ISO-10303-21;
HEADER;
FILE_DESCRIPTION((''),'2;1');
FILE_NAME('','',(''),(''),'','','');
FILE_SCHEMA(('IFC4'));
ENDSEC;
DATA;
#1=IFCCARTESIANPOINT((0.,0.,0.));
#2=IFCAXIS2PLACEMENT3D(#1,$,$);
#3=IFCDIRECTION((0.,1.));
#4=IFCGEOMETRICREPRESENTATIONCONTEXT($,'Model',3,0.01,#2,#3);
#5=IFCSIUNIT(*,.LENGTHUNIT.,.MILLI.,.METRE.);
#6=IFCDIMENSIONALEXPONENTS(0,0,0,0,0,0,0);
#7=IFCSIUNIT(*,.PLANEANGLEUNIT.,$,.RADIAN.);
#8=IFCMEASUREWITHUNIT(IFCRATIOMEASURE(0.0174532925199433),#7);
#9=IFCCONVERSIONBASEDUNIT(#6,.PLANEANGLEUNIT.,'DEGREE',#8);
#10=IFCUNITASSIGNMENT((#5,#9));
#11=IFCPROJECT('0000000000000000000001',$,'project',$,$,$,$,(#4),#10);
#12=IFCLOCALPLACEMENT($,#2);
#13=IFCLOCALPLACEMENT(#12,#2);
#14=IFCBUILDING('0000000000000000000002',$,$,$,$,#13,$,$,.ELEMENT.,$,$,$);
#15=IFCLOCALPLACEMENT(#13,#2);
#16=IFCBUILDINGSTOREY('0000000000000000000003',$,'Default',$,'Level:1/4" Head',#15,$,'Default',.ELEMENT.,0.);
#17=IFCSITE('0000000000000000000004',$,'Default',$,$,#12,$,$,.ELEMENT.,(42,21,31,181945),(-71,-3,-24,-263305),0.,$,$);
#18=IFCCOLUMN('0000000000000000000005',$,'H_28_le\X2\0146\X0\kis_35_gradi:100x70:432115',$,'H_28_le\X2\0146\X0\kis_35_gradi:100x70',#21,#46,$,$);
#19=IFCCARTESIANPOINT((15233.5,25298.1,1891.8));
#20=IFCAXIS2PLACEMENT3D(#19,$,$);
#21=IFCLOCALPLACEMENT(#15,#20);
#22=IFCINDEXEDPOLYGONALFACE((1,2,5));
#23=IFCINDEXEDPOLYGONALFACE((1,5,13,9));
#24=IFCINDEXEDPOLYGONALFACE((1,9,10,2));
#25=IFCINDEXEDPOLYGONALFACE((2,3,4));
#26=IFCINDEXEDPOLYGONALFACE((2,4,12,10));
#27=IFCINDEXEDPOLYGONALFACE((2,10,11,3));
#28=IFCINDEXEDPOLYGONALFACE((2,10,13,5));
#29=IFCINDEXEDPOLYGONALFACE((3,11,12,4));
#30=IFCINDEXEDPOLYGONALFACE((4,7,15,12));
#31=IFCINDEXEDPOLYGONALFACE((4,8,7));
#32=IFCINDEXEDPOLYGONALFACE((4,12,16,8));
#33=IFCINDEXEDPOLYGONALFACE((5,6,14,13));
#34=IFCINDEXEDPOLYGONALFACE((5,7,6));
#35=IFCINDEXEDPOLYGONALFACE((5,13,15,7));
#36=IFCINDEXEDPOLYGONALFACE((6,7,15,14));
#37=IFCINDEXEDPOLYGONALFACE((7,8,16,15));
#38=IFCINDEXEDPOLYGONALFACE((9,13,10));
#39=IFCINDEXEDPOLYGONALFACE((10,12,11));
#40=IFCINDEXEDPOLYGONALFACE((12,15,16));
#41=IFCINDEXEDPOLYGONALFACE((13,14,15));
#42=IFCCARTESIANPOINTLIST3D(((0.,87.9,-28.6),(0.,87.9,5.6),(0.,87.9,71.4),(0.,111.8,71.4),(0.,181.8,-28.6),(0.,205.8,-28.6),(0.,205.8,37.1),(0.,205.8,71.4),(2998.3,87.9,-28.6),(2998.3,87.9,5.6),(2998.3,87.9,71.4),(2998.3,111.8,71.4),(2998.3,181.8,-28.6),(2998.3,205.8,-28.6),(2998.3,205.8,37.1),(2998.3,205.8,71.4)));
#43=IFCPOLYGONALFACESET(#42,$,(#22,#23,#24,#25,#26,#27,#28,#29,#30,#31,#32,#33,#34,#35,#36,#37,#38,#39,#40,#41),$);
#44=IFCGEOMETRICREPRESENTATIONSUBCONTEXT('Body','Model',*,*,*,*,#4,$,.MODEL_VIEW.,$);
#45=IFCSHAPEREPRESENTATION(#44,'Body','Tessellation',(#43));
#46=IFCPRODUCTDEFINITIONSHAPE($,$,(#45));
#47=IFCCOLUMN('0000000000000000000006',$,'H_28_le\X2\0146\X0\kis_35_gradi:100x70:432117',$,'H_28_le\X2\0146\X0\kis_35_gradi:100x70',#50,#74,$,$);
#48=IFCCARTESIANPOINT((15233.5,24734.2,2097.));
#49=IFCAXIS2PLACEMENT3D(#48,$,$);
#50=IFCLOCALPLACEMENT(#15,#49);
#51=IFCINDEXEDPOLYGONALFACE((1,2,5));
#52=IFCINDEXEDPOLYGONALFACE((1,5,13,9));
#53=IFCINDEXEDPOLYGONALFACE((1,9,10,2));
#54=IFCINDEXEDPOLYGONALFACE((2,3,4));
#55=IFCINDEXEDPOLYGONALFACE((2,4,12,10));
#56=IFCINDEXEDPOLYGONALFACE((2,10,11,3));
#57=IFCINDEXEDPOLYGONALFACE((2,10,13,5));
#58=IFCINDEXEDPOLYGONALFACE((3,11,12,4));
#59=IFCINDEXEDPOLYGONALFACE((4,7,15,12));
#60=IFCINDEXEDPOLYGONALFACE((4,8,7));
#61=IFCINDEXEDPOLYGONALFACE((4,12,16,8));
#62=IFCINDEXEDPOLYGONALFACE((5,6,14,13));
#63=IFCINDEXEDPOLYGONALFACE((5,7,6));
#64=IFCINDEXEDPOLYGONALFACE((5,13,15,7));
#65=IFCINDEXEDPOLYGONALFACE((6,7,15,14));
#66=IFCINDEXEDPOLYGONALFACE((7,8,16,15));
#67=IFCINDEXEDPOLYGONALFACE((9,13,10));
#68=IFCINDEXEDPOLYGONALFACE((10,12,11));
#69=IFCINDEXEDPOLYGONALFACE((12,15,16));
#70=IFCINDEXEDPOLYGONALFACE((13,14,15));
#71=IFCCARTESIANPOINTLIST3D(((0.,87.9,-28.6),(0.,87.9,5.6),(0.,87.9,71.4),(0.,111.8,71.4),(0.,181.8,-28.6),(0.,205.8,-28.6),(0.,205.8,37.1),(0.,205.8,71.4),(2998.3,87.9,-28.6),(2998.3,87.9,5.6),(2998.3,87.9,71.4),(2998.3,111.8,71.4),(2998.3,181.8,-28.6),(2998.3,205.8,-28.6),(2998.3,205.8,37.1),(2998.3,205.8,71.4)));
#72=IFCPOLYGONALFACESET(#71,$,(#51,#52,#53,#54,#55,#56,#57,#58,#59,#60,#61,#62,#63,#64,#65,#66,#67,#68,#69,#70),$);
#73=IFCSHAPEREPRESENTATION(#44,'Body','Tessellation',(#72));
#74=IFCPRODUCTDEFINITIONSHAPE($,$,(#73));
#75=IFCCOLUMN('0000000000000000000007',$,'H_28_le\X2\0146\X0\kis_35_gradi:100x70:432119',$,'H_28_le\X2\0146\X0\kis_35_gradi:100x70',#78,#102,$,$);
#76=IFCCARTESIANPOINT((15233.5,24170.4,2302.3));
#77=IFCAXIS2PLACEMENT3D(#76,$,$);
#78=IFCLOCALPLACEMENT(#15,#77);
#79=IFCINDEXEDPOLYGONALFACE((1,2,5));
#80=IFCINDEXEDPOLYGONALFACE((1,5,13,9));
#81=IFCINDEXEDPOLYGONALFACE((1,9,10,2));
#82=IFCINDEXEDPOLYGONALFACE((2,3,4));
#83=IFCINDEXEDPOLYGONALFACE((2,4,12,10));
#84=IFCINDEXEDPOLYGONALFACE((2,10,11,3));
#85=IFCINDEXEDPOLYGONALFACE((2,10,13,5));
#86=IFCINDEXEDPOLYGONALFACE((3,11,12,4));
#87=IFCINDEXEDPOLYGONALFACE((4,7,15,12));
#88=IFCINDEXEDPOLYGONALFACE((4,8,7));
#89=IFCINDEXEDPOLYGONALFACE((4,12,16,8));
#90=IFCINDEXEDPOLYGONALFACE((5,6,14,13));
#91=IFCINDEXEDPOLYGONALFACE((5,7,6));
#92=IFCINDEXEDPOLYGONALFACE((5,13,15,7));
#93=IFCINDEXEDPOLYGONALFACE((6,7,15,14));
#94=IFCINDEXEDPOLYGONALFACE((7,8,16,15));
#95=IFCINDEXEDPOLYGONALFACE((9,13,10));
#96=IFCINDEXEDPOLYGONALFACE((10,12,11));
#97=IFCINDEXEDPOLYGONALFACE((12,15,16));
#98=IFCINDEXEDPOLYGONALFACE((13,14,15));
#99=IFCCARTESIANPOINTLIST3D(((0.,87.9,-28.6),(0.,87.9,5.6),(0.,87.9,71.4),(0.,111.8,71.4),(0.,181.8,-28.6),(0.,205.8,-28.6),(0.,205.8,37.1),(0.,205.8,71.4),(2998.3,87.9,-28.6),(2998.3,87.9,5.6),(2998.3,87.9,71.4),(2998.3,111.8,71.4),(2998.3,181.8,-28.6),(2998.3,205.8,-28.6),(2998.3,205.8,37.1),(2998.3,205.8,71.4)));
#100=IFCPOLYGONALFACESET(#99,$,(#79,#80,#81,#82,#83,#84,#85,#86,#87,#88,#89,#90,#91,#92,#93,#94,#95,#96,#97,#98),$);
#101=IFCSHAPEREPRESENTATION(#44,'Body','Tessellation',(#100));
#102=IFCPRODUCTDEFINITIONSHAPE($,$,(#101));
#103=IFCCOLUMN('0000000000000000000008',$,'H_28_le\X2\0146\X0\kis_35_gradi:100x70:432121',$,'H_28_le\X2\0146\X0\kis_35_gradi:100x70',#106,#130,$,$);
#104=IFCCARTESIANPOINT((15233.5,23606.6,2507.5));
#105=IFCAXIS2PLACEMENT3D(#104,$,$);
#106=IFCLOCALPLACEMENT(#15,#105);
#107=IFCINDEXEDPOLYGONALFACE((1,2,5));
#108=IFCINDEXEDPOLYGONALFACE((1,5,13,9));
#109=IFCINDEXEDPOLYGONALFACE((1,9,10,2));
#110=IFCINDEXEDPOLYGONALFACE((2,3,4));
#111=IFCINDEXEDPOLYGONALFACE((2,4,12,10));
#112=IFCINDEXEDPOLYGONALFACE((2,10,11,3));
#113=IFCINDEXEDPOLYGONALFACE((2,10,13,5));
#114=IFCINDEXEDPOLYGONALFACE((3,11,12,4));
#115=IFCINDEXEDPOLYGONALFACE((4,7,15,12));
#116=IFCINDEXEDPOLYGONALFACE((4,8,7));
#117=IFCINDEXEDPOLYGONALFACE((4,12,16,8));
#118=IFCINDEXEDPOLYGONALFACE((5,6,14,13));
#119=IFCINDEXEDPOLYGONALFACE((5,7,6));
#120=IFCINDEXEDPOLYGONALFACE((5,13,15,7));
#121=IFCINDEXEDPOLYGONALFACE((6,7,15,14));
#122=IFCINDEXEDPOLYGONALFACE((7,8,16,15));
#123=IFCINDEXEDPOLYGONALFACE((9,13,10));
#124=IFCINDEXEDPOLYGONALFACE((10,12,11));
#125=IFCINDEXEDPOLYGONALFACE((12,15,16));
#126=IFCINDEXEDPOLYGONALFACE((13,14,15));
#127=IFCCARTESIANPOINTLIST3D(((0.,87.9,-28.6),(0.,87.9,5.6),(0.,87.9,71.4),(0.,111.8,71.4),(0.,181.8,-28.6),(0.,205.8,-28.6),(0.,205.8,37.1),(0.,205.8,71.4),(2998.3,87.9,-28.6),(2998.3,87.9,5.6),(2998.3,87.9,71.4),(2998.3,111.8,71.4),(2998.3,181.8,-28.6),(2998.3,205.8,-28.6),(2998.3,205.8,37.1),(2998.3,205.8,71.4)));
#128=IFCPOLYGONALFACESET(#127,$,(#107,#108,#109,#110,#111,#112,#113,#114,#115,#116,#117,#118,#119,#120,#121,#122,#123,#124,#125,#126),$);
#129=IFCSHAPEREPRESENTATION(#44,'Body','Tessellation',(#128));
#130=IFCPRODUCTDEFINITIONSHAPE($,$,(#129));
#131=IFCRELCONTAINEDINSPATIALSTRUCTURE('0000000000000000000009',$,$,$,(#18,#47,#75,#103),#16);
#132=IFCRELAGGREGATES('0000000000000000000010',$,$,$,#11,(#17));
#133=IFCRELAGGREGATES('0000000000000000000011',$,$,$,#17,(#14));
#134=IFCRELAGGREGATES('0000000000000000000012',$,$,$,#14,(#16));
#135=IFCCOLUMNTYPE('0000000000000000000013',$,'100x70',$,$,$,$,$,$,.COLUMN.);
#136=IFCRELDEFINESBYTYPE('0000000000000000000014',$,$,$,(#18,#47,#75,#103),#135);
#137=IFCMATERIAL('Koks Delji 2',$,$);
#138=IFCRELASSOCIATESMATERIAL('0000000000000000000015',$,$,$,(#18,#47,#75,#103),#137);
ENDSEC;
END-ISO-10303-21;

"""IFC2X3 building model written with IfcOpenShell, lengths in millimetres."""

from ifc_helpers import new_model, entity, si_unit, converted_unit, direction, frame, frame_2d, origin, place, context, subcontext, project, spatial, rectangle, extrude, boolean, source, transform, mapped, material, type_object, type_shapes, element, save


model = new_model("IFC2X3")

# Units and contexts
model_context = context("Model", 3, precision=0.01, world=origin(), true_north=direction((0.0, 1.0)))
body_context = subcontext(model_context, "Body", "Model", "MODEL_VIEW")
ifc_project = project(units=[si_unit("LENGTHUNIT", "METRE", prefix="MILLI"), converted_unit("PLANEANGLEUNIT", "DEGREE", entity("IfcRatioMeasure", 0.0174532925199433), si_unit("PLANEANGLEUNIT", "RADIAN"), dimensions=[0, 0, 0, 0, 0, 0, 0])], contexts=[model_context])

# Site, building, storey
site_placement = place(None, origin())
site = spatial("IfcSite", under=ifc_project, at=site_placement, Name="Default", CompositionType="ELEMENT", RefLatitude=(42, 21, 31, 181945), RefLongitude=(-71, -3, -24, -263305), RefElevation=0.0)
building_placement = place(site_placement, origin())
building = spatial("IfcBuilding", under=site, at=building_placement, CompositionType="ELEMENT")
storey_placement = place(building_placement, origin())
storey = spatial("IfcBuildingStorey", under=building, at=storey_placement, Name="Default", ObjectType="Level:1/4\" Head", LongName="Default", CompositionType="ELEMENT", Elevation=0.0)

# Columns
ifc_material_1 = material(Name="Koks Delji 2")
column_type = type_object("IfcColumnType", Name="100x70", PredefinedType="COLUMN")
shared_shape_1 = source(origin(), body_context, "Body", "CSG", [
    boolean("DIFFERENCE", extrude(rectangle(XDim=2998.3, YDim=117.9, at=frame_2d((0.0, 0.0), x_axis=(1.0, 0.0))), frame((1499.1, 146.8, -28.6)), (0.0, 0.0, 1.0), 100.0), extrude(rectangle(XDim=70.0, YDim=100.0, at=frame_2d((0.0, 0.0), x_axis=(0.0, 1.0))), frame((2998.3, 146.8, 21.4), z_axis=(1.0, 0.0, 0.0), x_axis=(0.0, 0.939693, -0.34202)), (0.0, 0.0, -1.0), 2998.3)),
])
type_shapes(column_type, [shared_shape_1])
for number, where, name in (
    (1, (15233.5, 25298.1, 1891.8), "H_28_leņkis_35_gradi:100x70:432115"),
    (2, (15233.5, 24734.2, 2097.0), "H_28_leņkis_35_gradi:100x70:432117"),
    (3, (15233.5, 24170.4, 2302.3), "H_28_leņkis_35_gradi:100x70:432119"),
    (4, (15233.5, 23606.6, 2507.5), "H_28_leņkis_35_gradi:100x70:432121"),
):
    element("IfcColumn", number, at=place(storey_placement, frame(where)), inside=storey, type_object=column_type, material=ifc_material_1, Name=name, ObjectType="H_28_leņkis_35_gradi:100x70", context=body_context, shape_type="MappedRepresentation", body=[
        mapped(shared_shape_1, transform((0.0, 0.0, 0.0), scale=1.0)),
    ])

save(model, "model.ifc")
